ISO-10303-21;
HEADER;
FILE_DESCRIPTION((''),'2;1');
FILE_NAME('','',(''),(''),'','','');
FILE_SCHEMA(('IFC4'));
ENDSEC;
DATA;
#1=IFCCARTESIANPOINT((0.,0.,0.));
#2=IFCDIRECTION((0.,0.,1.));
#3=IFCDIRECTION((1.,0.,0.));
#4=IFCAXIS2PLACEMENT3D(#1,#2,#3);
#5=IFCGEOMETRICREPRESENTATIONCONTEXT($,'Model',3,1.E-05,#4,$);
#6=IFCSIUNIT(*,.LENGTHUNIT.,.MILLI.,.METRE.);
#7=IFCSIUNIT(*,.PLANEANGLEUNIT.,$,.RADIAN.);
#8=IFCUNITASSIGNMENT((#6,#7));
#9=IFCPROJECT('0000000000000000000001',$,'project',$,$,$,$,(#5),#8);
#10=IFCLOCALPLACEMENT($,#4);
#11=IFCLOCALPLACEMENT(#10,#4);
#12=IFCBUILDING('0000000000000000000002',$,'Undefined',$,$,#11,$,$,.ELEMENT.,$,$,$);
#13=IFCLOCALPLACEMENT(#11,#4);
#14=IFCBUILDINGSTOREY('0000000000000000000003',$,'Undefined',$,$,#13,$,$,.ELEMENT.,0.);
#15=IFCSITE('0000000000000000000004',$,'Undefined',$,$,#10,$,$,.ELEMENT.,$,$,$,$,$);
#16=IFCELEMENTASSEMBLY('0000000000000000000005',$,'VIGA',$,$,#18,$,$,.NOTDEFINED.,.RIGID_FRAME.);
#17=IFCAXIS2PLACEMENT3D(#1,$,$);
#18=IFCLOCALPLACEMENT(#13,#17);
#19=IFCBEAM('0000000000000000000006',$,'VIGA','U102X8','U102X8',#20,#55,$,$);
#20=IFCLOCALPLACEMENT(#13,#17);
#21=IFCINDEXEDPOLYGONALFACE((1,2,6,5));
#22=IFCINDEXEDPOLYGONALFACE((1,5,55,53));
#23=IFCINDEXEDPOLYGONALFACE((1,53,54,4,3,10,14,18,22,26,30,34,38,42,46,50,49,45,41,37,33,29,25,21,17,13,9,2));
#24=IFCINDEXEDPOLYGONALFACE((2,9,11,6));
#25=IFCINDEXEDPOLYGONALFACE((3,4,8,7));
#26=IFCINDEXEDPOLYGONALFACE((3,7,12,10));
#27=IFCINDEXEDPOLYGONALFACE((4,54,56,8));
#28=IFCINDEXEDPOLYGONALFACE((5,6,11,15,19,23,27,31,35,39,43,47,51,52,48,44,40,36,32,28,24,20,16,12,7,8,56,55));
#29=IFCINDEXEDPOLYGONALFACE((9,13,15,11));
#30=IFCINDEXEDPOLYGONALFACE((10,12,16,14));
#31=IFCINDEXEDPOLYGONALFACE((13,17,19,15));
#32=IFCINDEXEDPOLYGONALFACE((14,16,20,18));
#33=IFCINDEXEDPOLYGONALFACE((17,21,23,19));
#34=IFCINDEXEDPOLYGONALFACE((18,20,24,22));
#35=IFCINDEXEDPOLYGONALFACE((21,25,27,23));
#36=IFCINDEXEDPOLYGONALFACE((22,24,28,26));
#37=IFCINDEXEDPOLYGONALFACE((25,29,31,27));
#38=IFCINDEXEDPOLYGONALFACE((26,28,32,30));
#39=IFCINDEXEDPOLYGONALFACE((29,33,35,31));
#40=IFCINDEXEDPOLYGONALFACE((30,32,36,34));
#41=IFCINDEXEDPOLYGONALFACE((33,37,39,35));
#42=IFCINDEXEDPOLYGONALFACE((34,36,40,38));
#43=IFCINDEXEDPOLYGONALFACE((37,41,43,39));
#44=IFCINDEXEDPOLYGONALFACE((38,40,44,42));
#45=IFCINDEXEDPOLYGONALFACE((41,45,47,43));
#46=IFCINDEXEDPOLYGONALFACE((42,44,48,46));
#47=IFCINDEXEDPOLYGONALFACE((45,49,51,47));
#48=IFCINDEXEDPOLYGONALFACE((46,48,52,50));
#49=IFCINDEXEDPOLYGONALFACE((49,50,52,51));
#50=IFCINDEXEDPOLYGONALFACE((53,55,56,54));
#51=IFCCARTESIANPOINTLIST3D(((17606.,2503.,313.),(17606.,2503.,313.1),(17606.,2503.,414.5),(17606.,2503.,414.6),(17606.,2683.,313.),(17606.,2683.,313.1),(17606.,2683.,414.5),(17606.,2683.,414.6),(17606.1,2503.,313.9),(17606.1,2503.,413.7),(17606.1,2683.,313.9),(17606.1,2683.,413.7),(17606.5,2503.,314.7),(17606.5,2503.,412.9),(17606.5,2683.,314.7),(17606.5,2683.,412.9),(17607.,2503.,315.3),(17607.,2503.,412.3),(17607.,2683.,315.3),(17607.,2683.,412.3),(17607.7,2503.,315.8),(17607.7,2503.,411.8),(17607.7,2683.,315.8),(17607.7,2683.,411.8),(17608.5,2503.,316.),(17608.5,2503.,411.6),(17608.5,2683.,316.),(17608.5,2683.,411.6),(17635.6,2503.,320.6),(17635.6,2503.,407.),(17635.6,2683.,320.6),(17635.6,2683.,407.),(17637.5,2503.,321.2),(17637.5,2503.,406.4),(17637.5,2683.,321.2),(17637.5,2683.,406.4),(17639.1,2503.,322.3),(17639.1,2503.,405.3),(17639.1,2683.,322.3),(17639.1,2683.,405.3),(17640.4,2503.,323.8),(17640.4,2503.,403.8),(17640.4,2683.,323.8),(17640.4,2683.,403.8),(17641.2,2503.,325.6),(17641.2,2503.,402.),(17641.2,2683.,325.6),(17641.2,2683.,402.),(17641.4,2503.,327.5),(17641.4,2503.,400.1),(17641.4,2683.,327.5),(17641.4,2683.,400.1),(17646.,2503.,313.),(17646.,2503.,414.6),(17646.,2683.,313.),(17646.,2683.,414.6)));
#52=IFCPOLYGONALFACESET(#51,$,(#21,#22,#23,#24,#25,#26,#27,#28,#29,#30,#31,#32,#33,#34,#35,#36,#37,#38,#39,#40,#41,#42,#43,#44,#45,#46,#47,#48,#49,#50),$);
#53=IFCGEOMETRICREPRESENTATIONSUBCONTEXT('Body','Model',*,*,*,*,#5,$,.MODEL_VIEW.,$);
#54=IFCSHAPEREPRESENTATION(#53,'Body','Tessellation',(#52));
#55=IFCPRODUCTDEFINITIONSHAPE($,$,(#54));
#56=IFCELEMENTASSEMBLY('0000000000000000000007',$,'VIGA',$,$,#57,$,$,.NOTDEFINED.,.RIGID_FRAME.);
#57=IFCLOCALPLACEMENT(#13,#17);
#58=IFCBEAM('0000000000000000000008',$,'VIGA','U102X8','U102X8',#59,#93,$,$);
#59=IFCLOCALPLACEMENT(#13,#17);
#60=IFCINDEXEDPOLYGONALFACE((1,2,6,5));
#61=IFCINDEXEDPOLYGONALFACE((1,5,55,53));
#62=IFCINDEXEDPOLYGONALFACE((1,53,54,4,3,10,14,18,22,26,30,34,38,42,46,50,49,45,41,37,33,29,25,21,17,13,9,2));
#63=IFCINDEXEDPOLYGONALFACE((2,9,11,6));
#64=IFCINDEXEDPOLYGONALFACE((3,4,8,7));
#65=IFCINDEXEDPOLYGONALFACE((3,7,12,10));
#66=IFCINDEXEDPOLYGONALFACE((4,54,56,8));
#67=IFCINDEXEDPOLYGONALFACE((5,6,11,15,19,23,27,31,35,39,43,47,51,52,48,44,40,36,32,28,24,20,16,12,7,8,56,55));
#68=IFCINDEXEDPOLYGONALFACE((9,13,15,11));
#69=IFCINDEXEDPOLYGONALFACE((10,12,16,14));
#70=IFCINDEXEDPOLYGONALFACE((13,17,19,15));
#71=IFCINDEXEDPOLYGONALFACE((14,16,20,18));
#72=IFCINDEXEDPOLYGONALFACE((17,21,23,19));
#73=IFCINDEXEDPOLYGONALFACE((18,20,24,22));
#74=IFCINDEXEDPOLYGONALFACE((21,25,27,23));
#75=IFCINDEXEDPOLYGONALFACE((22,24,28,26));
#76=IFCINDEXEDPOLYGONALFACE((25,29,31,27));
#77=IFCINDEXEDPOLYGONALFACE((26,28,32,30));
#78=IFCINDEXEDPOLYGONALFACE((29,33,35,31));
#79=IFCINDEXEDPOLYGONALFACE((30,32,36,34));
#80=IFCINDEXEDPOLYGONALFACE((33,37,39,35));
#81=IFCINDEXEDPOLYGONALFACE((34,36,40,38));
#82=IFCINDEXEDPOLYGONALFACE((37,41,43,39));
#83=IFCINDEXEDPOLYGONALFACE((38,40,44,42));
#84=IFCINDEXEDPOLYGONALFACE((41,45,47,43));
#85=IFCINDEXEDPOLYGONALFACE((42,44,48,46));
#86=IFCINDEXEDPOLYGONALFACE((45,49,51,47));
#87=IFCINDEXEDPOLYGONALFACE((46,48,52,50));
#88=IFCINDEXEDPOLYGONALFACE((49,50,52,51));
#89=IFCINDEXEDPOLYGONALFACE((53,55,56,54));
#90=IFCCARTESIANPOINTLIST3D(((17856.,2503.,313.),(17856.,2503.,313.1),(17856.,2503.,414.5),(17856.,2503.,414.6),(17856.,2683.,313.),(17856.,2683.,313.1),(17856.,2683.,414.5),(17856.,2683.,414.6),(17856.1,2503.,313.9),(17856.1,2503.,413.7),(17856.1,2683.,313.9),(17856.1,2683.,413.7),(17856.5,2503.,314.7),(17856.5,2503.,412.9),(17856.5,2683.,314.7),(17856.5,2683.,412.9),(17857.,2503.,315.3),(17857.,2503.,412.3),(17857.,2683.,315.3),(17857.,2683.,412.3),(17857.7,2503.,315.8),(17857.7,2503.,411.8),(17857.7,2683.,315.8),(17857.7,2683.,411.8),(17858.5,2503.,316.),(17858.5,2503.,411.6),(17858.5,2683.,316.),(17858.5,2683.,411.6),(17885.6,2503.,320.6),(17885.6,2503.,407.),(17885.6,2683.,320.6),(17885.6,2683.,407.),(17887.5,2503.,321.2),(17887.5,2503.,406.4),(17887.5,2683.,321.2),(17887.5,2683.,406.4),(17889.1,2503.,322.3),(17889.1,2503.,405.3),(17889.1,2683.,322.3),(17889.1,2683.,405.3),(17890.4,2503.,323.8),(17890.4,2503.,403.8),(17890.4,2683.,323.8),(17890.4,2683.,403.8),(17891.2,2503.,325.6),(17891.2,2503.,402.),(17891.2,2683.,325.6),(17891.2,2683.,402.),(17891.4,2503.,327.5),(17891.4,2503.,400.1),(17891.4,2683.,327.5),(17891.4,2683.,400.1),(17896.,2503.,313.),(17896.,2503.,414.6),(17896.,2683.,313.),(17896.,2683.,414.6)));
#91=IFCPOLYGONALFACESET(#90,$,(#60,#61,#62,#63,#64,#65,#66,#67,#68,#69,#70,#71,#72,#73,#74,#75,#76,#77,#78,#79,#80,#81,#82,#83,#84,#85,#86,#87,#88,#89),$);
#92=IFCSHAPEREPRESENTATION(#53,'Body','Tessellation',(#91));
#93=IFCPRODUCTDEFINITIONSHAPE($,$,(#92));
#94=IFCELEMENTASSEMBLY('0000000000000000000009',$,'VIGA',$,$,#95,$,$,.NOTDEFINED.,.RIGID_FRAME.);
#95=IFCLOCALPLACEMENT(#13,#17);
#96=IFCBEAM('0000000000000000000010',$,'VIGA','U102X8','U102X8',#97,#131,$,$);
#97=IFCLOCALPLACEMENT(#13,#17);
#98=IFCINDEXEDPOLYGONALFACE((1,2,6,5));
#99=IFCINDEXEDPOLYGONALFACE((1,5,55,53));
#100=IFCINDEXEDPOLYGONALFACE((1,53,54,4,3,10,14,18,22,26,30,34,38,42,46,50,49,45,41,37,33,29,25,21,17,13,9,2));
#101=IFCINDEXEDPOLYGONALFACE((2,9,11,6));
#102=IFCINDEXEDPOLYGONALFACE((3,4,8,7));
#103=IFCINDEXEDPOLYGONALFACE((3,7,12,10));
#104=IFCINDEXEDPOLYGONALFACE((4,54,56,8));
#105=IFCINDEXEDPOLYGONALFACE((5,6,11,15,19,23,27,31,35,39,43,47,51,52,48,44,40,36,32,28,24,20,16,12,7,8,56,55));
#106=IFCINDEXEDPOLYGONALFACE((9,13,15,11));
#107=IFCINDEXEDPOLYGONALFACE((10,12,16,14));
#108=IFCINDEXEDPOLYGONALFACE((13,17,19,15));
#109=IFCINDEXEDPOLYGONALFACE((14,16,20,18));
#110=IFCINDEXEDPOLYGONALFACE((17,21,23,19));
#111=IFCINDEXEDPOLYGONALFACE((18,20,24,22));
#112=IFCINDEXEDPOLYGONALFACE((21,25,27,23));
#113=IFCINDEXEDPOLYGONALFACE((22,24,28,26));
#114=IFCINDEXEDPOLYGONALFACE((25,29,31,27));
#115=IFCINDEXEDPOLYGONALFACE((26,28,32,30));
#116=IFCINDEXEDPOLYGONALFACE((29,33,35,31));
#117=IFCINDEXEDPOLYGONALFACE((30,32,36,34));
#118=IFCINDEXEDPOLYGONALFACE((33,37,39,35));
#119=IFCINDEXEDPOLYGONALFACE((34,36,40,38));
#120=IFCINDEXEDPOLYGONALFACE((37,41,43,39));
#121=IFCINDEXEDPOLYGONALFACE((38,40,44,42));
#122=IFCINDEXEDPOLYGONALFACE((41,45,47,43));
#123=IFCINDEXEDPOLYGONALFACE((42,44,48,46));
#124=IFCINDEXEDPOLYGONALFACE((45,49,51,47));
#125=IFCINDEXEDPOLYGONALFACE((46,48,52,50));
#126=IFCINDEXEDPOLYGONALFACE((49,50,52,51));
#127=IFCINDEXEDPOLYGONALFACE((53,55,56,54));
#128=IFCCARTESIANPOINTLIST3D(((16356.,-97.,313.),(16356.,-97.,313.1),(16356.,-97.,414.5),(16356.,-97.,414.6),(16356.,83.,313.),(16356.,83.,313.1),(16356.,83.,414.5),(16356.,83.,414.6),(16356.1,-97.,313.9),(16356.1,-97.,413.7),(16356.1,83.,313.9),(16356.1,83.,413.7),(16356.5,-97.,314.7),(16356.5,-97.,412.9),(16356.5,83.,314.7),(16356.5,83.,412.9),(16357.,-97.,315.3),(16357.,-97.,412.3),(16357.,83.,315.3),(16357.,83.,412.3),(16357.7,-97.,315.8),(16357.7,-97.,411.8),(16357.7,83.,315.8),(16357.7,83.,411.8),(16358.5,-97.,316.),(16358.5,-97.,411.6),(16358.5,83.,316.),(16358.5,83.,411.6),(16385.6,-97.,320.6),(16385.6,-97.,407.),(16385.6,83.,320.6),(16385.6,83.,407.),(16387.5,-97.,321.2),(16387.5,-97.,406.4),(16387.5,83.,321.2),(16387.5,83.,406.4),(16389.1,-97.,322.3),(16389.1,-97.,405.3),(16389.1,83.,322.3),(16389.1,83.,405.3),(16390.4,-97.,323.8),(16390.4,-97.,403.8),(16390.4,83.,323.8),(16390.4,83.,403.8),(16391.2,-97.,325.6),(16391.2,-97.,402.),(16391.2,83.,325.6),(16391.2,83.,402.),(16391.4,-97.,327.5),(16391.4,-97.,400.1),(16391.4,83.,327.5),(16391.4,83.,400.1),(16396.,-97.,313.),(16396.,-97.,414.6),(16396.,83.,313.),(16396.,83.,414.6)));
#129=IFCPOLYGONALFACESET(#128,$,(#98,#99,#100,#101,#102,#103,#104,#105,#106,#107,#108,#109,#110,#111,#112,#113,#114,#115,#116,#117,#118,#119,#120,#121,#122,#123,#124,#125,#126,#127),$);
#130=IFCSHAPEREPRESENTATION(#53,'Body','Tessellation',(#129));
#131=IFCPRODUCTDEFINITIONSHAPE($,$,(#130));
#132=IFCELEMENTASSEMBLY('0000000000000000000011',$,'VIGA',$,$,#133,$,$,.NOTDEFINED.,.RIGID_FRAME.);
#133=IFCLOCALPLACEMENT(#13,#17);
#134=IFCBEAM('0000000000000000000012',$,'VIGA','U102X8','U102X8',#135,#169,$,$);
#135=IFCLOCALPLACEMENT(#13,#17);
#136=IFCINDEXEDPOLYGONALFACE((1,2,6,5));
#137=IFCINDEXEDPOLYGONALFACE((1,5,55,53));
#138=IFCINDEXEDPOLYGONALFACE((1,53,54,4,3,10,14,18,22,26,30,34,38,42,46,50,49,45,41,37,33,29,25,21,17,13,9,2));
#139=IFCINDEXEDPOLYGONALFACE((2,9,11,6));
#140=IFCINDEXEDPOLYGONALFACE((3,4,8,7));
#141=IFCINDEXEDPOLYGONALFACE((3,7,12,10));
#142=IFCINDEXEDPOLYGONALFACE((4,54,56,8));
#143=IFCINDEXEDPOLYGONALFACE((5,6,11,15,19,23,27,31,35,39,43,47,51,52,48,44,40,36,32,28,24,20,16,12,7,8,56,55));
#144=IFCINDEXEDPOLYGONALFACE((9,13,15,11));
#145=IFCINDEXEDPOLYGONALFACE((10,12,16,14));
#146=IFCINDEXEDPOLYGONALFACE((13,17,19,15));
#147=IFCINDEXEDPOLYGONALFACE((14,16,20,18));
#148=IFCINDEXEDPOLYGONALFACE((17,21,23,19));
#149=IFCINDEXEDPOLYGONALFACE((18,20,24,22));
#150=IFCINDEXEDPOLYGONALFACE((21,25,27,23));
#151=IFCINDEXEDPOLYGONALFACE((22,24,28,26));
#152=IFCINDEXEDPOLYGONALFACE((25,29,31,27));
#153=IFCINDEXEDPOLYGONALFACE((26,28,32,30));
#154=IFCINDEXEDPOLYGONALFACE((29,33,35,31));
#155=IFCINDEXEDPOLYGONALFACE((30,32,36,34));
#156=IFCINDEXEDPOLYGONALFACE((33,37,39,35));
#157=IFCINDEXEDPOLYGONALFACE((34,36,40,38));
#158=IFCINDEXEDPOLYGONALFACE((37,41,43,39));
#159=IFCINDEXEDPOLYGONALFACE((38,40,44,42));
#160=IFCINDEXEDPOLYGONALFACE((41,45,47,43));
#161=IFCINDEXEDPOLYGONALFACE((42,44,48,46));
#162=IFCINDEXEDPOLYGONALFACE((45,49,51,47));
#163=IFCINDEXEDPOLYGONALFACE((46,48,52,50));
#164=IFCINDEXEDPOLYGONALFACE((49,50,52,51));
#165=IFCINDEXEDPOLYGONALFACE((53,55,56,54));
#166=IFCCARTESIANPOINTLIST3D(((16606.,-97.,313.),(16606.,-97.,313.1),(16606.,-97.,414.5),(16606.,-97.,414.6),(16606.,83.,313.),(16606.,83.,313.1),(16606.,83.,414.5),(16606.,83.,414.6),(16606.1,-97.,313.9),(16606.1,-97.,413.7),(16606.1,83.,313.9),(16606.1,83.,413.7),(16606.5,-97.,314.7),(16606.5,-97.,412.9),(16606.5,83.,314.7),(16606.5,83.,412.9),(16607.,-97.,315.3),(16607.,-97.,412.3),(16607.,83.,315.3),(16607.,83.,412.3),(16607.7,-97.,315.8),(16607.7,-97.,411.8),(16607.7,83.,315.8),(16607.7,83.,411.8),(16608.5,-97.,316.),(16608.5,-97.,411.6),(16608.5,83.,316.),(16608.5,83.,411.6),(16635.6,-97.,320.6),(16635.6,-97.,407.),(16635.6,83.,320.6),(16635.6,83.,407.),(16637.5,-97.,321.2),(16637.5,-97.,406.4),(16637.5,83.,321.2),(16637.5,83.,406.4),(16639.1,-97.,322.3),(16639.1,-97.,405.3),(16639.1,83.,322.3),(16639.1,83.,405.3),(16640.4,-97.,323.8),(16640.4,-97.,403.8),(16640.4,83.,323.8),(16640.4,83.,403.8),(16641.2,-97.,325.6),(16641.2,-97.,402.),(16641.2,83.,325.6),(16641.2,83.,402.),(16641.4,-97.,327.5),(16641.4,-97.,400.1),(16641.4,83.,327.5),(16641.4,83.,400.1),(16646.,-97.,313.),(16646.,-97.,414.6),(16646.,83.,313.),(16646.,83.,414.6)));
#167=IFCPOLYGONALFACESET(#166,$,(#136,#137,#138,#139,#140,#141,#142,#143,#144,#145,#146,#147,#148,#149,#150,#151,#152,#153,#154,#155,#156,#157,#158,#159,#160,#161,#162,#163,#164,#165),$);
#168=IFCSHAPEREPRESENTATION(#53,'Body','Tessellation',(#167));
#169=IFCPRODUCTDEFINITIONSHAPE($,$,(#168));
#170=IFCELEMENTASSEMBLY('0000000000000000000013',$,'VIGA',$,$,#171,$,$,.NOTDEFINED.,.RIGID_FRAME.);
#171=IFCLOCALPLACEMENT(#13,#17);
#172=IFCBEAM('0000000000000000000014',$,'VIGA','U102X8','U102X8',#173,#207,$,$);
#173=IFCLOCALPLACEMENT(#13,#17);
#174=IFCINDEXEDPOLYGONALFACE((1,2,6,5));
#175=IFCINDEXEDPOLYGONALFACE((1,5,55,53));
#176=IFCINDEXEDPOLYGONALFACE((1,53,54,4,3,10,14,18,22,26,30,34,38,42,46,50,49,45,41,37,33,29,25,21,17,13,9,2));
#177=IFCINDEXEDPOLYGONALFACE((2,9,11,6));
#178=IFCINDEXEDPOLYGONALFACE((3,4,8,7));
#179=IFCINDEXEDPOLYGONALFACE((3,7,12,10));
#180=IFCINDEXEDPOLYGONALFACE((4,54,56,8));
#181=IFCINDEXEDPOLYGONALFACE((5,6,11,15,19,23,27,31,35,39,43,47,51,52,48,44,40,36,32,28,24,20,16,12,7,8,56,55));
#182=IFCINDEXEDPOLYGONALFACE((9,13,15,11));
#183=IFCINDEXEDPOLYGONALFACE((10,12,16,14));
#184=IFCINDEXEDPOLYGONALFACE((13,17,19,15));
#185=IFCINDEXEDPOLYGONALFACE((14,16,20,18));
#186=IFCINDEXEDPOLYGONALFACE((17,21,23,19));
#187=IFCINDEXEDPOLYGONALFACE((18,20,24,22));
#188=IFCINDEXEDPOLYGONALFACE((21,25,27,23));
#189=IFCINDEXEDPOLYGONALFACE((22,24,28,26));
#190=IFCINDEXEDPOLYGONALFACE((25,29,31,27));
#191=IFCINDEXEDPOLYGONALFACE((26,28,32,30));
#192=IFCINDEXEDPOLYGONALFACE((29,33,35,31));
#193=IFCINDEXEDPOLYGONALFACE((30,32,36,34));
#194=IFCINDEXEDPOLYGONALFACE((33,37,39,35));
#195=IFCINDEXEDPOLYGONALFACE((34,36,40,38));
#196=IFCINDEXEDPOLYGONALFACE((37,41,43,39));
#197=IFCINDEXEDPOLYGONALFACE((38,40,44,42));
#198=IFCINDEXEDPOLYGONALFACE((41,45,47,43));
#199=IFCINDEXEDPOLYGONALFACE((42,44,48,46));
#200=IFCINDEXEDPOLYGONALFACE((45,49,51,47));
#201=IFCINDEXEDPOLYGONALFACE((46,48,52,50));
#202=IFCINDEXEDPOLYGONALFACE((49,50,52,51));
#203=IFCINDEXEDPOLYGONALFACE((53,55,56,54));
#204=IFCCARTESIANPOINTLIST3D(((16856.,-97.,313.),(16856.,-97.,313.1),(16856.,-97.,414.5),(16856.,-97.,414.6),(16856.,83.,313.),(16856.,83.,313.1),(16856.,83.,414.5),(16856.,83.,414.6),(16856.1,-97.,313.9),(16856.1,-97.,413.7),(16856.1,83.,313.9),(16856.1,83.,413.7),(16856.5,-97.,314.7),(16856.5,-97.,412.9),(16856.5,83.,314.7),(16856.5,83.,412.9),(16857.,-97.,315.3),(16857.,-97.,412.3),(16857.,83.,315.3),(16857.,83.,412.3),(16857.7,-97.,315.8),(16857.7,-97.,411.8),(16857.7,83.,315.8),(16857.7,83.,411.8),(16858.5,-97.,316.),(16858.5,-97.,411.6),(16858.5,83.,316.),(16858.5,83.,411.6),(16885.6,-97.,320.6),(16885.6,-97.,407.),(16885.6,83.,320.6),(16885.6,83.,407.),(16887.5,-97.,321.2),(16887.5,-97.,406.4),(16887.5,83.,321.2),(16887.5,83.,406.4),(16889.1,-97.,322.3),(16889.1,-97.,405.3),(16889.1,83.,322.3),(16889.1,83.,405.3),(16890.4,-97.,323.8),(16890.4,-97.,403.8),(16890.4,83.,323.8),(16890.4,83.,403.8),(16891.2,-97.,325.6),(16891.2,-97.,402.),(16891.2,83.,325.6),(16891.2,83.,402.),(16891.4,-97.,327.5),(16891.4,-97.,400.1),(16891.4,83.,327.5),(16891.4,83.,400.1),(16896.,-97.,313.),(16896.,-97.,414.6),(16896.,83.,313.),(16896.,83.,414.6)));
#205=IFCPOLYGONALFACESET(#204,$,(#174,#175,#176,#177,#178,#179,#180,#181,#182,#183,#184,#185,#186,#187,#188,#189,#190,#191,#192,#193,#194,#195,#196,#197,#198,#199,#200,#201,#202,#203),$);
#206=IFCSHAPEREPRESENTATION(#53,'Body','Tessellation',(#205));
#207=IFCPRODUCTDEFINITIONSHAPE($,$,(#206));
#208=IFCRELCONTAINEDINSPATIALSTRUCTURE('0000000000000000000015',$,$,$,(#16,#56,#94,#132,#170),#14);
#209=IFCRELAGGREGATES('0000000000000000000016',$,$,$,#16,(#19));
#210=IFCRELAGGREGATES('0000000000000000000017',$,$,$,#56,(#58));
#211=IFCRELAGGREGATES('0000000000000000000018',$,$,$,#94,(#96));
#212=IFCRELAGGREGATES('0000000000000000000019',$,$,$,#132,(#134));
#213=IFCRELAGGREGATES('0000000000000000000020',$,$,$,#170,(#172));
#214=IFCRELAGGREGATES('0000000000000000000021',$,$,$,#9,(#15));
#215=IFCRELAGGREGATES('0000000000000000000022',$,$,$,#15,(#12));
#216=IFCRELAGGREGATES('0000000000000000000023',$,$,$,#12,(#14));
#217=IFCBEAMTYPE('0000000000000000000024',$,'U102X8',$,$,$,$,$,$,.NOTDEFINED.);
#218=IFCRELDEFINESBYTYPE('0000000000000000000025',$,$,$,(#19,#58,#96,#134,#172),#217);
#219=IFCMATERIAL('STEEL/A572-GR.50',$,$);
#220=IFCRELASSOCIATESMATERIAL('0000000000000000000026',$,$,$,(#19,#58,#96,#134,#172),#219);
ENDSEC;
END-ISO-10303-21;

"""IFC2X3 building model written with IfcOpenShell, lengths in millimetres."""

from ifc_helpers import new_model, si_unit, frame, origin_with_axes, origin_2d_with_axis, place, context, subcontext, project, spatial, u_section, extrude, material, type_object, element, aggregate, save


model = new_model("IFC2X3")

# Units and contexts
model_context = context("Model", 3, precision=1e-05, world=origin_with_axes())
body_context = subcontext(model_context, "Body", "Model", "MODEL_VIEW")
ifc_project = project(units=[si_unit("LENGTHUNIT", "METRE", prefix="MILLI"), si_unit("PLANEANGLEUNIT", "RADIAN")], contexts=[model_context])

# Site, building, storey
site_placement = place(None, origin_with_axes())
site = spatial("IfcSite", under=ifc_project, at=site_placement, Name="Undefined", CompositionType="ELEMENT")
building_placement = place(site_placement, origin_with_axes())
building = spatial("IfcBuilding", under=site, at=building_placement, Name="Undefined", CompositionType="ELEMENT")
storey_placement = place(building_placement, origin_with_axes())
storey = spatial("IfcBuildingStorey", under=building, at=storey_placement, Name="Undefined", CompositionType="ELEMENT", Elevation=0.0)

# Element assemblies, beams
ifc_material_1 = material(Name="STEEL/A572-GR.50")
beam_type_1 = type_object("IfcBeamType", Name="U102X8", PredefinedType="NOTDEFINED")
assembly_1_placement = place(storey_placement, origin_with_axes())
assembly_1 = element("IfcElementAssembly", 1, at=assembly_1_placement, inside=storey, Name="VIGA", AssemblyPlace="NOTDEFINED", PredefinedType="RIGID_FRAME")
beam_1_placement = place(assembly_1_placement, frame((17626.0, 2683.0, 363.8), z_axis=(0.0, 0.0, 1.0), x_axis=(0.0, -1.0, 0.0)))
beam_1 = element("IfcBeam", 2, at=beam_1_placement, type_object=beam_type_1, material=ifc_material_1, Name="VIGA", Description="U102X8", ObjectType="U102X8", context=body_context, shape_type="SweptSolid", body=[
    extrude(u_section(Depth=101.6, FlangeWidth=40.0, WebThickness=4.6, FlangeThickness=6.0, FilletRadius=7.0, EdgeRadius=3.0, FlangeSlope=0.16839, at=origin_2d_with_axis()), frame((180.0, 0.0, 0.0), z_axis=(-1.0, 0.0, 0.0), x_axis=(0.0, -1.0, 0.0)), (0.0, 0.0, 1.0), 180.0),
])
aggregate(assembly_1, [beam_1])
assembly_2_placement = place(storey_placement, origin_with_axes())
assembly_2 = element("IfcElementAssembly", 3, at=assembly_2_placement, inside=storey, Name="VIGA", AssemblyPlace="NOTDEFINED", PredefinedType="RIGID_FRAME")
beam_2_placement = place(assembly_2_placement, frame((17876.0, 2683.0, 363.8), z_axis=(0.0, 0.0, 1.0), x_axis=(0.0, -1.0, 0.0)))
beam_2 = element("IfcBeam", 4, at=beam_2_placement, type_object=beam_type_1, material=ifc_material_1, Name="VIGA", Description="U102X8", ObjectType="U102X8", context=body_context, shape_type="SweptSolid", body=[
    extrude(u_section(Depth=101.6, FlangeWidth=40.0, WebThickness=4.6, FlangeThickness=6.0, FilletRadius=7.0, EdgeRadius=3.0, FlangeSlope=0.16839, at=origin_2d_with_axis()), frame((180.0, 0.0, 0.0), z_axis=(-1.0, 0.0, 0.0), x_axis=(0.0, -1.0, 0.0)), (0.0, 0.0, 1.0), 180.0),
])
aggregate(assembly_2, [beam_2])
assembly_3_placement = place(storey_placement, origin_with_axes())
assembly_3 = element("IfcElementAssembly", 5, at=assembly_3_placement, inside=storey, Name="VIGA", AssemblyPlace="NOTDEFINED", PredefinedType="RIGID_FRAME")
beam_3_placement = place(assembly_3_placement, frame((16376.0, 83.0, 363.8), z_axis=(0.0, 0.0, 1.0), x_axis=(0.0, -1.0, 0.0)))
beam_3 = element("IfcBeam", 6, at=beam_3_placement, type_object=beam_type_1, material=ifc_material_1, Name="VIGA", Description="U102X8", ObjectType="U102X8", context=body_context, shape_type="SweptSolid", body=[
    extrude(u_section(Depth=101.6, FlangeWidth=40.0, WebThickness=4.6, FlangeThickness=6.0, FilletRadius=7.0, EdgeRadius=3.0, FlangeSlope=0.16839, at=origin_2d_with_axis()), frame((180.0, 0.0, 0.0), z_axis=(-1.0, 0.0, 0.0), x_axis=(0.0, -1.0, 0.0)), (0.0, 0.0, 1.0), 180.0),
])
aggregate(assembly_3, [beam_3])
assembly_4_placement = place(storey_placement, origin_with_axes())
assembly_4 = element("IfcElementAssembly", 7, at=assembly_4_placement, inside=storey, Name="VIGA", AssemblyPlace="NOTDEFINED", PredefinedType="RIGID_FRAME")
beam_4_placement = place(assembly_4_placement, frame((16626.0, 83.0, 363.8), z_axis=(0.0, 0.0, 1.0), x_axis=(0.0, -1.0, 0.0)))
beam_4 = element("IfcBeam", 8, at=beam_4_placement, type_object=beam_type_1, material=ifc_material_1, Name="VIGA", Description="U102X8", ObjectType="U102X8", context=body_context, shape_type="SweptSolid", body=[
    extrude(u_section(Depth=101.6, FlangeWidth=40.0, WebThickness=4.6, FlangeThickness=6.0, FilletRadius=7.0, EdgeRadius=3.0, FlangeSlope=0.16839, at=origin_2d_with_axis()), frame((180.0, 0.0, 0.0), z_axis=(-1.0, 0.0, 0.0), x_axis=(0.0, -1.0, 0.0)), (0.0, 0.0, 1.0), 180.0),
])
aggregate(assembly_4, [beam_4])
assembly_5_placement = place(storey_placement, origin_with_axes())
assembly_5 = element("IfcElementAssembly", 9, at=assembly_5_placement, inside=storey, Name="VIGA", AssemblyPlace="NOTDEFINED", PredefinedType="RIGID_FRAME")
beam_5_placement = place(assembly_5_placement, frame((16876.0, 83.0, 363.8), z_axis=(0.0, 0.0, 1.0), x_axis=(0.0, -1.0, 0.0)))
beam_5 = element("IfcBeam", 10, at=beam_5_placement, type_object=beam_type_1, material=ifc_material_1, Name="VIGA", Description="U102X8", ObjectType="U102X8", context=body_context, shape_type="SweptSolid", body=[
    extrude(u_section(Depth=101.6, FlangeWidth=40.0, WebThickness=4.6, FlangeThickness=6.0, FilletRadius=7.0, EdgeRadius=3.0, FlangeSlope=0.16839, at=origin_2d_with_axis()), frame((180.0, 0.0, 0.0), z_axis=(-1.0, 0.0, 0.0), x_axis=(0.0, -1.0, 0.0)), (0.0, 0.0, 1.0), 180.0),
])
aggregate(assembly_5, [beam_5])

save(model, "model.ifc")
